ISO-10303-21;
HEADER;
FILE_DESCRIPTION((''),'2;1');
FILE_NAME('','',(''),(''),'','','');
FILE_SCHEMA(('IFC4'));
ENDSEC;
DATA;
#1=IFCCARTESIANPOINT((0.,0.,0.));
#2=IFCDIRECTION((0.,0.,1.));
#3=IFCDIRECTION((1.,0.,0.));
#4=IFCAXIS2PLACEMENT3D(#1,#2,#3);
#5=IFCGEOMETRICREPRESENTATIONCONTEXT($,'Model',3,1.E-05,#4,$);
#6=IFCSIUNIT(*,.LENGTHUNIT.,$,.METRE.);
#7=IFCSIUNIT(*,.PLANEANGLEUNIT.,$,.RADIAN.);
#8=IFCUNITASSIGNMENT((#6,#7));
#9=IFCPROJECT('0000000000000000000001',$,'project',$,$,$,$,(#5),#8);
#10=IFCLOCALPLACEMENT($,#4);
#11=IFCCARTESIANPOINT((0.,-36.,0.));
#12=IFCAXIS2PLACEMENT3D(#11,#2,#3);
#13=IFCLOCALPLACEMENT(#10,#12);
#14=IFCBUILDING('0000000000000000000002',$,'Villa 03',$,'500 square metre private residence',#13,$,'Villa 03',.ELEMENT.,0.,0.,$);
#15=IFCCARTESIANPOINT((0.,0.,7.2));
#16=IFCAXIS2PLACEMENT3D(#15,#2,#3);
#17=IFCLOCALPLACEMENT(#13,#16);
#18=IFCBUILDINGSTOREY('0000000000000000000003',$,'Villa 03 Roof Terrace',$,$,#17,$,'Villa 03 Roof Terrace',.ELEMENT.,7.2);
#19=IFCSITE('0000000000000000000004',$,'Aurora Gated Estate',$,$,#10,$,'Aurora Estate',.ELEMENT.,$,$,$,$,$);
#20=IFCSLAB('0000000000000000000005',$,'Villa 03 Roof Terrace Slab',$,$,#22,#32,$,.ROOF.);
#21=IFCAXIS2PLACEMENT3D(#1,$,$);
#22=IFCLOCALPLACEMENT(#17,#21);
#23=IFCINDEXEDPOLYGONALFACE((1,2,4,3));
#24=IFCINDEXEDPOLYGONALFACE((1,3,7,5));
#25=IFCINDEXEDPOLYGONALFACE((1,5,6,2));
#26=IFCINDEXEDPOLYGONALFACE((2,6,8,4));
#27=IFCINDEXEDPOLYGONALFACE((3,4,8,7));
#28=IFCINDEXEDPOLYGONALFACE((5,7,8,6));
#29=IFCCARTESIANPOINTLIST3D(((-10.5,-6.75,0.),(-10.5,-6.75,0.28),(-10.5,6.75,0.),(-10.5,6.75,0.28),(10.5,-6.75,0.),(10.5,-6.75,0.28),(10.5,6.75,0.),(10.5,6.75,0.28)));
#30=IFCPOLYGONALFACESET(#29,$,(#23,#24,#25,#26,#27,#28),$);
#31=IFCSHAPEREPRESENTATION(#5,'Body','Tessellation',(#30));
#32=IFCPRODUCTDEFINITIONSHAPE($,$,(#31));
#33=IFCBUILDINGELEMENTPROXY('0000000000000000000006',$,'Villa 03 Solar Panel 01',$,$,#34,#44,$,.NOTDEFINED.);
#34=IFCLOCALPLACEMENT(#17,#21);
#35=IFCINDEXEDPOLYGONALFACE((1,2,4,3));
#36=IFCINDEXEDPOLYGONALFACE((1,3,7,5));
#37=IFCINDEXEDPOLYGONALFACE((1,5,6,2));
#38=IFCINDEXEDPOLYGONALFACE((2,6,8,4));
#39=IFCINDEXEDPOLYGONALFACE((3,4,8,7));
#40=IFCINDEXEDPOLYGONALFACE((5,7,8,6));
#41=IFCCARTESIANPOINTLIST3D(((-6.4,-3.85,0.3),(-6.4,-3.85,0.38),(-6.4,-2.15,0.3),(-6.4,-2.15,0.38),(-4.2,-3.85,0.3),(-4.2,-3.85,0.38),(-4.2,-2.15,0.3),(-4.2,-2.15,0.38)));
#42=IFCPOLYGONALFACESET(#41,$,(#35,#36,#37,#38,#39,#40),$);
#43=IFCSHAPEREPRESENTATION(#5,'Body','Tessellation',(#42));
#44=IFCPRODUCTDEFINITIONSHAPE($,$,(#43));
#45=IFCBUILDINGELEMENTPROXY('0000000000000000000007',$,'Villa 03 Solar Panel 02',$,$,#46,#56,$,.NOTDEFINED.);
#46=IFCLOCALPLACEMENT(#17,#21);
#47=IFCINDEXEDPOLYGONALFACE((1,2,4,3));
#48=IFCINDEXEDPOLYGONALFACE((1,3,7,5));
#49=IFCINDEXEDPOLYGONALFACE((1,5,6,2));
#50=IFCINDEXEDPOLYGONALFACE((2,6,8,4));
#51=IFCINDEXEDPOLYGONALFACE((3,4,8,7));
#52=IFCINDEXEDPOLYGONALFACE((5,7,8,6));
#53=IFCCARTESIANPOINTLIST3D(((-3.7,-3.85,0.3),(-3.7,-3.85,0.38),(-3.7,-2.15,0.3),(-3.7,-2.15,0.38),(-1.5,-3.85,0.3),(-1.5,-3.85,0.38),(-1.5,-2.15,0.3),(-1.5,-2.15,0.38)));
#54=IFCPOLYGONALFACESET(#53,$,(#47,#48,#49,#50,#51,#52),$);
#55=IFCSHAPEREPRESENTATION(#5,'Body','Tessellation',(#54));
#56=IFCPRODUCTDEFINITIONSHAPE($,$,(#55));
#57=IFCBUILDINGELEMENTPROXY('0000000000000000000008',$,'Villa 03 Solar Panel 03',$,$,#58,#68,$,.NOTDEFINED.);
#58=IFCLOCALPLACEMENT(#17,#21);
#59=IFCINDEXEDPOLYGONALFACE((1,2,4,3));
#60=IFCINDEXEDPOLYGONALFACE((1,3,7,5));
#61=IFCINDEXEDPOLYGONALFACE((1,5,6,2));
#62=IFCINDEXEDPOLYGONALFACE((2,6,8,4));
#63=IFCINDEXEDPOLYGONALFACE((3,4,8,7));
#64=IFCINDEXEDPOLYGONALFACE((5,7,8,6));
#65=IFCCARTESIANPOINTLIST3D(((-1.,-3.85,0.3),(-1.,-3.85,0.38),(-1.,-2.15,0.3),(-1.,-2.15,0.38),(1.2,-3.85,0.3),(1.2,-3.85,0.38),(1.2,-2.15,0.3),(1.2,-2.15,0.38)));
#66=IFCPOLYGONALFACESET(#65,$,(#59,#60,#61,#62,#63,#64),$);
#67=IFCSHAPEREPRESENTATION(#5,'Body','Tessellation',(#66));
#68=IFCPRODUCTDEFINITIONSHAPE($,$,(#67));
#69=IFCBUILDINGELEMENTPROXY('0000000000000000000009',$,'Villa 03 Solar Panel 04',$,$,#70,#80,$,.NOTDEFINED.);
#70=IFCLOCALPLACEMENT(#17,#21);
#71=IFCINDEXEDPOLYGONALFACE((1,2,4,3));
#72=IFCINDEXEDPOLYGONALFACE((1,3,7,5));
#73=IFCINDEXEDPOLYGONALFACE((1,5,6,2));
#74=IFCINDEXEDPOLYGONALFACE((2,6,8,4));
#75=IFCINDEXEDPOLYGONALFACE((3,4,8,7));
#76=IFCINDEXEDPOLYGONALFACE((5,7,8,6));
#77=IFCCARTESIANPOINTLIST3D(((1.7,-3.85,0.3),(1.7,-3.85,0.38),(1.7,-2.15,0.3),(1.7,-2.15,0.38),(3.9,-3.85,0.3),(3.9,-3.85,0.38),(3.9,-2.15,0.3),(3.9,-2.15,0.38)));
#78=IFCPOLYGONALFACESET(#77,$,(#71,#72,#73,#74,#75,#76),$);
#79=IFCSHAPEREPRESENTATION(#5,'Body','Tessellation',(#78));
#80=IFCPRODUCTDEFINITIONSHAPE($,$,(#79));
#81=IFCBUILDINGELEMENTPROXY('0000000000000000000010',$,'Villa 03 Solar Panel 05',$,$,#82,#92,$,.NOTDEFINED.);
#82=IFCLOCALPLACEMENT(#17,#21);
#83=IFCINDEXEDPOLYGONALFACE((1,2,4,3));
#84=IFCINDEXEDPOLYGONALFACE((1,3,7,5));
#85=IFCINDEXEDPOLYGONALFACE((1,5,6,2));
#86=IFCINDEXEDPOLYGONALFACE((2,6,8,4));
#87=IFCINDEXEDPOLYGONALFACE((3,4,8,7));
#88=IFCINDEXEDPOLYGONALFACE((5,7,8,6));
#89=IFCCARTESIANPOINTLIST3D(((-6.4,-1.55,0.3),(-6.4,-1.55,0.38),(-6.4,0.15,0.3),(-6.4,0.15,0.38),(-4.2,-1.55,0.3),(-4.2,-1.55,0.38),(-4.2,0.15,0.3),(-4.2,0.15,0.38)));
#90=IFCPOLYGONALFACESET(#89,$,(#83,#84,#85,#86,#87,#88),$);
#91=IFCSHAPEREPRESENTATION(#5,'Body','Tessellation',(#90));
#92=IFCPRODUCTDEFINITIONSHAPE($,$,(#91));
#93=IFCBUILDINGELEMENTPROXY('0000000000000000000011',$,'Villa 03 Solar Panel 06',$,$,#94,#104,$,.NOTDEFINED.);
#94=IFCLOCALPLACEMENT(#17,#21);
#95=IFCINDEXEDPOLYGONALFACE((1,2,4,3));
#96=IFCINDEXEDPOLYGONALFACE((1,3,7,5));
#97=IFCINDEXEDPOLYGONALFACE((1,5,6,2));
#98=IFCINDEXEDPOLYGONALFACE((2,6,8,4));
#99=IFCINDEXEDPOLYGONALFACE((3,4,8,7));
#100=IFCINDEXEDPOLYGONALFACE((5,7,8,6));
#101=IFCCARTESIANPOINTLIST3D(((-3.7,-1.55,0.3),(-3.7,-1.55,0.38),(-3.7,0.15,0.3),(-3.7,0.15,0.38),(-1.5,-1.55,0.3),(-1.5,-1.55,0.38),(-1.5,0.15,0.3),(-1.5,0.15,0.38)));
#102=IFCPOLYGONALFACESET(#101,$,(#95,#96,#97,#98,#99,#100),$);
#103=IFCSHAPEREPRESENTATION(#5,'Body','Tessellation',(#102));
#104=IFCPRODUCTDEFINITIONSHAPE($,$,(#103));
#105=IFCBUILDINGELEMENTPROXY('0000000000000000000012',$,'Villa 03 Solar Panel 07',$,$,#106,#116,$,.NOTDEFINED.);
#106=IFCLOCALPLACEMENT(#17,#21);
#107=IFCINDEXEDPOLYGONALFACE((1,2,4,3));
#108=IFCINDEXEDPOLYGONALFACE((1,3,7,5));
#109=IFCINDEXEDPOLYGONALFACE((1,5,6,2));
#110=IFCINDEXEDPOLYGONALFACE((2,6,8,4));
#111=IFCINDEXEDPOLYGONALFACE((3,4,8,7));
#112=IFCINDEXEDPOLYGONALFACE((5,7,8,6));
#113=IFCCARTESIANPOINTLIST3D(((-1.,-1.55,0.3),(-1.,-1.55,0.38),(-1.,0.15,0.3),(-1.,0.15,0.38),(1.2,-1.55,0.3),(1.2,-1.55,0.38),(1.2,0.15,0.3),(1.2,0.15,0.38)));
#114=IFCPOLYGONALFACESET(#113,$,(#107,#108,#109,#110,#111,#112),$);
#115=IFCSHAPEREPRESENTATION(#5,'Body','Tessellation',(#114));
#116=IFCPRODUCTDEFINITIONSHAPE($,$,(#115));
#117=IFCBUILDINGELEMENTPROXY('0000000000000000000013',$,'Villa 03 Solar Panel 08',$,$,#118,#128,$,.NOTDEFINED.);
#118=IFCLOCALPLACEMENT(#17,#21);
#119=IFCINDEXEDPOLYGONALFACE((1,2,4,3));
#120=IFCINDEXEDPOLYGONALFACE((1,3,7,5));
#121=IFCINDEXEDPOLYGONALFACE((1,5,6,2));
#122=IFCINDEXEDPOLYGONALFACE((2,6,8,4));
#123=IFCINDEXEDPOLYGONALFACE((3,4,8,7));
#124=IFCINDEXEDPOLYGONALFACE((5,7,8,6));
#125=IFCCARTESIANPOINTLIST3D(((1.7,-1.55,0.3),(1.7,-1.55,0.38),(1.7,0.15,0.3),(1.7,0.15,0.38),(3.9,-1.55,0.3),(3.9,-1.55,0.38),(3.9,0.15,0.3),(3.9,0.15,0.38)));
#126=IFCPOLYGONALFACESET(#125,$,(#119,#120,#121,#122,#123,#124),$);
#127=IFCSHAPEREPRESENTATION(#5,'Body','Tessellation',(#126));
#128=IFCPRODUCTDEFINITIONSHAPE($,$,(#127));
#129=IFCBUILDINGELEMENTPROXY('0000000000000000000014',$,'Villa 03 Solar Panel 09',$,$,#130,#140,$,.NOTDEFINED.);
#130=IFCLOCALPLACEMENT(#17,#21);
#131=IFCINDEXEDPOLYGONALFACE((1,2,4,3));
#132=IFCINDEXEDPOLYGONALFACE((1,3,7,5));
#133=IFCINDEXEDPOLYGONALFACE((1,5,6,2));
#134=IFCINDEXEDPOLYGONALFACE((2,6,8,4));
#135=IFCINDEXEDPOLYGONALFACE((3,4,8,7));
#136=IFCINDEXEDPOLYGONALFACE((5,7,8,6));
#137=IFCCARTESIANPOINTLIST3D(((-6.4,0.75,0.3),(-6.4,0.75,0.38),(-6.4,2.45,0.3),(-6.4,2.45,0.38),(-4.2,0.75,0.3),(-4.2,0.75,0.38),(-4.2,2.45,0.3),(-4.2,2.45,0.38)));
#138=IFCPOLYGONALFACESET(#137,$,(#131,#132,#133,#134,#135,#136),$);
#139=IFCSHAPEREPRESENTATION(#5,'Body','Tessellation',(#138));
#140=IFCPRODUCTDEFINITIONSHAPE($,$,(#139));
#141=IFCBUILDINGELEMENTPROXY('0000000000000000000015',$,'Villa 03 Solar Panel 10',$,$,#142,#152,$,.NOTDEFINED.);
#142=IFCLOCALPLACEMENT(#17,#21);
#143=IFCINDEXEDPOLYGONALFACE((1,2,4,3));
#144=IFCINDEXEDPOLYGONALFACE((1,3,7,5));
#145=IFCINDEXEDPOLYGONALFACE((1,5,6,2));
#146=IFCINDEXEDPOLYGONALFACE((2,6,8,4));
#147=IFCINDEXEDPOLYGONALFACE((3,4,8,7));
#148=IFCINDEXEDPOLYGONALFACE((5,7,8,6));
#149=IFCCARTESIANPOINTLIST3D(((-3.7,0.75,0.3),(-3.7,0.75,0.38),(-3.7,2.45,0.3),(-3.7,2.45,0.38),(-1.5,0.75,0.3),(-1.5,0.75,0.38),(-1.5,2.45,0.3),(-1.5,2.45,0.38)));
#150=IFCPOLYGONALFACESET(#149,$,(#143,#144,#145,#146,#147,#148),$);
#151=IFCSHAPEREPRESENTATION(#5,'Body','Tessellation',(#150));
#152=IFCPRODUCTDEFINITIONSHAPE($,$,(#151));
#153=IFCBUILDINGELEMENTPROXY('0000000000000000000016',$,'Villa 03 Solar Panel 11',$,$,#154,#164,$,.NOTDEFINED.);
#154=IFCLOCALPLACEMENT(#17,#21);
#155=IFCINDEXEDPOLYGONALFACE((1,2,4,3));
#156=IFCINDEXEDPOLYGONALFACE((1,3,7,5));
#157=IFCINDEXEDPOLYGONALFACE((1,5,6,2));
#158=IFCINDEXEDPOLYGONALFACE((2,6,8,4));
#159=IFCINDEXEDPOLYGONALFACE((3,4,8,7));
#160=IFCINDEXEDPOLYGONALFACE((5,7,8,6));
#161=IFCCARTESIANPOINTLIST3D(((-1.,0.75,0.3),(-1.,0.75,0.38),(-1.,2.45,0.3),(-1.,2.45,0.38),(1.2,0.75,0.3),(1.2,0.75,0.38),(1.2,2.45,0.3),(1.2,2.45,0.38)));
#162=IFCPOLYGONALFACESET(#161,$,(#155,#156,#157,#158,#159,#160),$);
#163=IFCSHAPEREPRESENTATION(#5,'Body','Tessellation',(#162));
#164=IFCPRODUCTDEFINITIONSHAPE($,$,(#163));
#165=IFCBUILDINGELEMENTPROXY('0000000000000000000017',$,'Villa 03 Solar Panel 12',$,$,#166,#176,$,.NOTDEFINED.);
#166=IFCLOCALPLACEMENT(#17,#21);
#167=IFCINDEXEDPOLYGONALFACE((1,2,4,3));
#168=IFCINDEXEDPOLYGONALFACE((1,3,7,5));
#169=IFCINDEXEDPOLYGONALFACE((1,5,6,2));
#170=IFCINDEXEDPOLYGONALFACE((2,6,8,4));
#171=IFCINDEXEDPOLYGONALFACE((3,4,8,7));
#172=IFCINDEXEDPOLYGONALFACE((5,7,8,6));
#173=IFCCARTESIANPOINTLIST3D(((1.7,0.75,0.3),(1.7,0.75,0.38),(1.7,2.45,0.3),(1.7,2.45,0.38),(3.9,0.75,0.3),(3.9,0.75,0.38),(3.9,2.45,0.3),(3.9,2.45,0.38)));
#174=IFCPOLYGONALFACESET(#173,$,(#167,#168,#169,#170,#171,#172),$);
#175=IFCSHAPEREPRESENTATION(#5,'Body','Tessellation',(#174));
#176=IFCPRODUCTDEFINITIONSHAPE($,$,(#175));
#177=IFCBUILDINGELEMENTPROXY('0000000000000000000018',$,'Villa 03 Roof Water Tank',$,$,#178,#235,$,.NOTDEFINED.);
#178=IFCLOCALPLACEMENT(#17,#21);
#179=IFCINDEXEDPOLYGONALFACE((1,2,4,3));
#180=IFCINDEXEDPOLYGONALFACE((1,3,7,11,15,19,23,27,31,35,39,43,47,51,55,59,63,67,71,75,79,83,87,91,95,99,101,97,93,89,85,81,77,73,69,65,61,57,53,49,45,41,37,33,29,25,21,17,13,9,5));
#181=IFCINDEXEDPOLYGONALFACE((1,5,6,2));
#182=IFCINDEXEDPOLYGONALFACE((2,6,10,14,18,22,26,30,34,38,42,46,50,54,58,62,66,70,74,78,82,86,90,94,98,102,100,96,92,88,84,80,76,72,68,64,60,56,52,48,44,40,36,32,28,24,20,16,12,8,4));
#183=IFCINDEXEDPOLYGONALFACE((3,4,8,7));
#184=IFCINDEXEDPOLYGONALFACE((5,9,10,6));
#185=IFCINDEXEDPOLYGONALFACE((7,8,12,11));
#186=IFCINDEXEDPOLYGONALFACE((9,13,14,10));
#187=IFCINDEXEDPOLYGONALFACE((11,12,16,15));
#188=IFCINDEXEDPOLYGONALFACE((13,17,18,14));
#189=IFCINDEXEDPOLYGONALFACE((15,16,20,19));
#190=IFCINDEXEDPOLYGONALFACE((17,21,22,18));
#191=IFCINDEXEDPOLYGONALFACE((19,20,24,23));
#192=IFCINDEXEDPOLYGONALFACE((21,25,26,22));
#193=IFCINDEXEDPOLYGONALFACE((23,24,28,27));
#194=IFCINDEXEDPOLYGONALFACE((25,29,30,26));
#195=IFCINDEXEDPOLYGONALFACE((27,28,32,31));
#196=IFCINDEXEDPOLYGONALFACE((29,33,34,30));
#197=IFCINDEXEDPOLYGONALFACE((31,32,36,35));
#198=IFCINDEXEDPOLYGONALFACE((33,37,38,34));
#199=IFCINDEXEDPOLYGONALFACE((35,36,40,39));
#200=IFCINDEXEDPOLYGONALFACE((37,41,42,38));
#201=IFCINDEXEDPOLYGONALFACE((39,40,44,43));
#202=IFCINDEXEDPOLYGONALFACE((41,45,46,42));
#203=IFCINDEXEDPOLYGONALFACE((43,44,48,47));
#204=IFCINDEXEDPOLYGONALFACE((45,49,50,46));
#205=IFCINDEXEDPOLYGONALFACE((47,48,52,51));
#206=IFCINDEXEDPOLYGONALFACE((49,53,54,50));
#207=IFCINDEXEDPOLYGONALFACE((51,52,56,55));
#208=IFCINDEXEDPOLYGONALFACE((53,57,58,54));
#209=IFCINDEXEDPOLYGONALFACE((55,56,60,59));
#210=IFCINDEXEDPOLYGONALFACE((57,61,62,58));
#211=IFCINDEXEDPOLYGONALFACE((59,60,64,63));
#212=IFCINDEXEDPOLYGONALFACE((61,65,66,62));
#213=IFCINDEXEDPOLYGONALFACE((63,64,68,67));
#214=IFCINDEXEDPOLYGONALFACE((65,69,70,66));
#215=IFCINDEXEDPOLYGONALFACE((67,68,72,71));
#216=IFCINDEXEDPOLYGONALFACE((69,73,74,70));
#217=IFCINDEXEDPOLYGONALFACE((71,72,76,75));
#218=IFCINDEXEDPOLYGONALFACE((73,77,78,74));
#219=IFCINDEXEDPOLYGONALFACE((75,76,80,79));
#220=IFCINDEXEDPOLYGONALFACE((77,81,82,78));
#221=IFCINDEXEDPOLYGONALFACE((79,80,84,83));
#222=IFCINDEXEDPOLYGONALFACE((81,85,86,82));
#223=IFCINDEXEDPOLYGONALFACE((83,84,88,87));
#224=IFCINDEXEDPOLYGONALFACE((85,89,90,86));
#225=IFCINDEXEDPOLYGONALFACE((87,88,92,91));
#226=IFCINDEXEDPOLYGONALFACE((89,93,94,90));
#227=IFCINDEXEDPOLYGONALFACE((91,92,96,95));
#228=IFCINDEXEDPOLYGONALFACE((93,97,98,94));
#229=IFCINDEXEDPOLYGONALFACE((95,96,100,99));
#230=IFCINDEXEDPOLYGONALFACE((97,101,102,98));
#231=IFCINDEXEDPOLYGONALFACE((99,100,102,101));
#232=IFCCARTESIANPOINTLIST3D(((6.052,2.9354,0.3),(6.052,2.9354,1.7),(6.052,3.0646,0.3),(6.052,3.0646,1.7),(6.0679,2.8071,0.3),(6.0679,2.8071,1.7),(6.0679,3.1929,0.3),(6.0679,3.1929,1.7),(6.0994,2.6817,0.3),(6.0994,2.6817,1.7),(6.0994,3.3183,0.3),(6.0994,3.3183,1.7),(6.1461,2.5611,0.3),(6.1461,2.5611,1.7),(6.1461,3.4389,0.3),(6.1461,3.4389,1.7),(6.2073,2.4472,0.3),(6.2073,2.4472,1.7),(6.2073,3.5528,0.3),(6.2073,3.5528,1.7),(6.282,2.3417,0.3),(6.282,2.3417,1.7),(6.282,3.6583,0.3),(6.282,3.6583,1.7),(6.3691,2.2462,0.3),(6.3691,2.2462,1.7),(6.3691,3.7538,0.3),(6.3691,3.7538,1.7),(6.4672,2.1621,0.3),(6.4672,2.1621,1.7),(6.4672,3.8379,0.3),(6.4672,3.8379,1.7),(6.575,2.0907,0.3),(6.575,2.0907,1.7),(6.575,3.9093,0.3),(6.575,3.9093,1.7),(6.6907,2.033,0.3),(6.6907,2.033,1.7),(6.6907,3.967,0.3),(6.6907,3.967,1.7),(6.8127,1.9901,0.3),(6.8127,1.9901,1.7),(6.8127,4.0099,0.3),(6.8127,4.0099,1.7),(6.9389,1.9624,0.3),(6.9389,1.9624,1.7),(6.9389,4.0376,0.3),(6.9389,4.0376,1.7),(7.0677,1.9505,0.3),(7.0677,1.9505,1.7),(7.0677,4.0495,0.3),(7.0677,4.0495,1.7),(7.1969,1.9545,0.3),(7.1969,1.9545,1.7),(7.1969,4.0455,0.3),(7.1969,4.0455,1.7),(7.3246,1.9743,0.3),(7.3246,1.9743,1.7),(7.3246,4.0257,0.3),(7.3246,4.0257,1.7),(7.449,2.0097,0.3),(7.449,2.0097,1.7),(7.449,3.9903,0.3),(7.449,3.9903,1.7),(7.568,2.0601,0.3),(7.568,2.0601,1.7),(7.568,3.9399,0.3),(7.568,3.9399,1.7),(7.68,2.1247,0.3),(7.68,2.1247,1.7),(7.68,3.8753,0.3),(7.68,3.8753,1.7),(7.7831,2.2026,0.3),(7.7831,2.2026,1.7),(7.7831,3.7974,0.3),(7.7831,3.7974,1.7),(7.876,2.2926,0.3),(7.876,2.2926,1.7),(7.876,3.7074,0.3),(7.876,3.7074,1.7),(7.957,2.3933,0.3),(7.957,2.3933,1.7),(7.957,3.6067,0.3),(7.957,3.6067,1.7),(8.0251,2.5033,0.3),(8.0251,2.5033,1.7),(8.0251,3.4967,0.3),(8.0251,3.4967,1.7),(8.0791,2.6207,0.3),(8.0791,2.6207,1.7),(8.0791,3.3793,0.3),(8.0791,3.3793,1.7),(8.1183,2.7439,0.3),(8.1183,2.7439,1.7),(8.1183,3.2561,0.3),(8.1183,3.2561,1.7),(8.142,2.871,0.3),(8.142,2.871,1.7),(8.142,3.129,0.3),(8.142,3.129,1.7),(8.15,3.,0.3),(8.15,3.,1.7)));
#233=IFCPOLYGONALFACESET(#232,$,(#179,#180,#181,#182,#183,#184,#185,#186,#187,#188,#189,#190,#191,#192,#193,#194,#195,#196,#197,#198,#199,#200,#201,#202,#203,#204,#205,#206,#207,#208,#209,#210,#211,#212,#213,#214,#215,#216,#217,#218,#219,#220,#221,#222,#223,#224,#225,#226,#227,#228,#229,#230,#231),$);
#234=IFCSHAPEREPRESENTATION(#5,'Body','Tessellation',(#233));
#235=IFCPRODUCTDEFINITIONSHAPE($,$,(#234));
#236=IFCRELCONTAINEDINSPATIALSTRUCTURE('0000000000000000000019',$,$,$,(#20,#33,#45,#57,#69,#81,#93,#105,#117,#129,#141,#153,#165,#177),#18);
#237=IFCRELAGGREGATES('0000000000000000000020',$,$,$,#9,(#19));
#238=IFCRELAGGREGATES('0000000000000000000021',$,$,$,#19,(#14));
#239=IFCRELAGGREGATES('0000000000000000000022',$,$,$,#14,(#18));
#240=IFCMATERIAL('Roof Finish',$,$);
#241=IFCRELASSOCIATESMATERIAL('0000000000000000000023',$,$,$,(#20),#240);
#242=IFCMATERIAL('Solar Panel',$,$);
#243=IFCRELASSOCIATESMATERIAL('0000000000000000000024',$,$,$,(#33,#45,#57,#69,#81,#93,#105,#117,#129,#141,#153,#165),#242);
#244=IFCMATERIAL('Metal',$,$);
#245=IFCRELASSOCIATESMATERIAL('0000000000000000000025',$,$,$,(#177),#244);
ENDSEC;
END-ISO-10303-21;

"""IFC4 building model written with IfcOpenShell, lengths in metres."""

from ifc_helpers import new_model, si_unit, frame, origin_with_axes, origin_2d_with_axis, place, context, project, spatial, rectangle, circle, extrude, material, element, save


model = new_model("IFC4")

# Units and contexts
model_context = context("Model", 3, precision=1e-05, world=origin_with_axes())
ifc_project = project(units=[si_unit("LENGTHUNIT", "METRE"), si_unit("PLANEANGLEUNIT", "RADIAN")], contexts=[model_context])

# Site, building, storey
site_placement = place(None, origin_with_axes())
site = spatial("IfcSite", under=ifc_project, at=site_placement, Name="Aurora Gated Estate", LongName="Aurora Estate", CompositionType="ELEMENT")
building_placement = place(site_placement, frame((0.0, -36.0, 0.0), z_axis=(0.0, 0.0, 1.0), x_axis=(1.0, 0.0, 0.0)))
building = spatial("IfcBuilding", under=site, at=building_placement, Name="Villa 03", ObjectType="500 square metre private residence", LongName="Villa 03", CompositionType="ELEMENT", ElevationOfRefHeight=0.0, ElevationOfTerrain=0.0)
storey_placement = place(building_placement, frame((0.0, 0.0, 7.2), z_axis=(0.0, 0.0, 1.0), x_axis=(1.0, 0.0, 0.0)))
storey = spatial("IfcBuildingStorey", under=building, at=storey_placement, Name="Villa 03 Roof Terrace", LongName="Villa 03 Roof Terrace", CompositionType="ELEMENT", Elevation=7.2)

# Slab
ifc_material_1 = material(Name="Roof Finish")
slab_placement = place(storey_placement, origin_with_axes())
element("IfcSlab", 1, at=slab_placement, inside=storey, material=ifc_material_1, Name="Villa 03 Roof Terrace Slab", PredefinedType="ROOF", context=model_context, shape_type="SweptSolid", body=[
    extrude(rectangle(XDim=21.0, YDim=13.5, at=origin_2d_with_axis()), origin_with_axes(), (0.0, 0.0, 1.0), 0.28),
])

# Building element proxies
ifc_material_2 = material(Name="Solar Panel")
for number, where, z_axis, x_axis, name in (
    (2, (-5.3, -3.0, 0.3), (0.0, 0.0, 1.0), (1.0, 0.0, 0.0), "Villa 03 Solar Panel 01"),
    (3, (-2.6, -3.0, 0.3), (0.0, 0.0, 1.0), (1.0, 0.0, 0.0), "Villa 03 Solar Panel 02"),
    (4, (0.1, -3.0, 0.3), (0.0, 0.0, 1.0), (1.0, 0.0, 0.0), "Villa 03 Solar Panel 03"),
    (5, (2.8, -3.0, 0.3), (0.0, 0.0, 1.0), (1.0, 0.0, 0.0), "Villa 03 Solar Panel 04"),
    (6, (-5.3, -0.7, 0.3), (0.0, 0.0, 1.0), (1.0, 0.0, 0.0), "Villa 03 Solar Panel 05"),
    (7, (-2.6, -0.7, 0.3), (0.0, 0.0, 1.0), (1.0, 0.0, 0.0), "Villa 03 Solar Panel 06"),
    (8, (0.1, -0.7, 0.3), (0.0, 0.0, 1.0), (1.0, 0.0, 0.0), "Villa 03 Solar Panel 07"),
    (9, (2.8, -0.7, 0.3), (0.0, 0.0, 1.0), (1.0, 0.0, 0.0), "Villa 03 Solar Panel 08"),
    (10, (-5.3, 1.6, 0.3), (0.0, 0.0, 1.0), (1.0, 0.0, 0.0), "Villa 03 Solar Panel 09"),
    (11, (-2.6, 1.6, 0.3), (0.0, 0.0, 1.0), (1.0, 0.0, 0.0), "Villa 03 Solar Panel 10"),
    (12, (0.1, 1.6, 0.3), (0.0, 0.0, 1.0), (1.0, 0.0, 0.0), "Villa 03 Solar Panel 11"),
    (13, (2.8, 1.6, 0.3), (0.0, 0.0, 1.0), (1.0, 0.0, 0.0), "Villa 03 Solar Panel 12"),
):
    element("IfcBuildingElementProxy", number, at=place(storey_placement, frame(where, z_axis=z_axis, x_axis=x_axis)), inside=storey, material=ifc_material_2, Name=name, PredefinedType="NOTDEFINED", context=model_context, shape_type="SweptSolid", body=[
        extrude(rectangle(XDim=2.2, YDim=1.7, at=origin_2d_with_axis()), origin_with_axes(), (0.0, 0.0, 1.0), 0.08),
    ])
ifc_material_3 = material(Name="Metal")
proxy_1_placement = place(storey_placement, frame((7.1, 3.0, 0.3), z_axis=(0.0, 0.0, 1.0), x_axis=(1.0, 0.0, 0.0)))
element("IfcBuildingElementProxy", 14, at=proxy_1_placement, inside=storey, material=ifc_material_3, Name="Villa 03 Roof Water Tank", PredefinedType="NOTDEFINED", context=model_context, shape_type="SweptSolid", body=[
    extrude(circle(Radius=1.05, at=origin_2d_with_axis()), origin_with_axes(), (0.0, 0.0, 1.0), 1.4),
])

save(model, "model.ifc")
